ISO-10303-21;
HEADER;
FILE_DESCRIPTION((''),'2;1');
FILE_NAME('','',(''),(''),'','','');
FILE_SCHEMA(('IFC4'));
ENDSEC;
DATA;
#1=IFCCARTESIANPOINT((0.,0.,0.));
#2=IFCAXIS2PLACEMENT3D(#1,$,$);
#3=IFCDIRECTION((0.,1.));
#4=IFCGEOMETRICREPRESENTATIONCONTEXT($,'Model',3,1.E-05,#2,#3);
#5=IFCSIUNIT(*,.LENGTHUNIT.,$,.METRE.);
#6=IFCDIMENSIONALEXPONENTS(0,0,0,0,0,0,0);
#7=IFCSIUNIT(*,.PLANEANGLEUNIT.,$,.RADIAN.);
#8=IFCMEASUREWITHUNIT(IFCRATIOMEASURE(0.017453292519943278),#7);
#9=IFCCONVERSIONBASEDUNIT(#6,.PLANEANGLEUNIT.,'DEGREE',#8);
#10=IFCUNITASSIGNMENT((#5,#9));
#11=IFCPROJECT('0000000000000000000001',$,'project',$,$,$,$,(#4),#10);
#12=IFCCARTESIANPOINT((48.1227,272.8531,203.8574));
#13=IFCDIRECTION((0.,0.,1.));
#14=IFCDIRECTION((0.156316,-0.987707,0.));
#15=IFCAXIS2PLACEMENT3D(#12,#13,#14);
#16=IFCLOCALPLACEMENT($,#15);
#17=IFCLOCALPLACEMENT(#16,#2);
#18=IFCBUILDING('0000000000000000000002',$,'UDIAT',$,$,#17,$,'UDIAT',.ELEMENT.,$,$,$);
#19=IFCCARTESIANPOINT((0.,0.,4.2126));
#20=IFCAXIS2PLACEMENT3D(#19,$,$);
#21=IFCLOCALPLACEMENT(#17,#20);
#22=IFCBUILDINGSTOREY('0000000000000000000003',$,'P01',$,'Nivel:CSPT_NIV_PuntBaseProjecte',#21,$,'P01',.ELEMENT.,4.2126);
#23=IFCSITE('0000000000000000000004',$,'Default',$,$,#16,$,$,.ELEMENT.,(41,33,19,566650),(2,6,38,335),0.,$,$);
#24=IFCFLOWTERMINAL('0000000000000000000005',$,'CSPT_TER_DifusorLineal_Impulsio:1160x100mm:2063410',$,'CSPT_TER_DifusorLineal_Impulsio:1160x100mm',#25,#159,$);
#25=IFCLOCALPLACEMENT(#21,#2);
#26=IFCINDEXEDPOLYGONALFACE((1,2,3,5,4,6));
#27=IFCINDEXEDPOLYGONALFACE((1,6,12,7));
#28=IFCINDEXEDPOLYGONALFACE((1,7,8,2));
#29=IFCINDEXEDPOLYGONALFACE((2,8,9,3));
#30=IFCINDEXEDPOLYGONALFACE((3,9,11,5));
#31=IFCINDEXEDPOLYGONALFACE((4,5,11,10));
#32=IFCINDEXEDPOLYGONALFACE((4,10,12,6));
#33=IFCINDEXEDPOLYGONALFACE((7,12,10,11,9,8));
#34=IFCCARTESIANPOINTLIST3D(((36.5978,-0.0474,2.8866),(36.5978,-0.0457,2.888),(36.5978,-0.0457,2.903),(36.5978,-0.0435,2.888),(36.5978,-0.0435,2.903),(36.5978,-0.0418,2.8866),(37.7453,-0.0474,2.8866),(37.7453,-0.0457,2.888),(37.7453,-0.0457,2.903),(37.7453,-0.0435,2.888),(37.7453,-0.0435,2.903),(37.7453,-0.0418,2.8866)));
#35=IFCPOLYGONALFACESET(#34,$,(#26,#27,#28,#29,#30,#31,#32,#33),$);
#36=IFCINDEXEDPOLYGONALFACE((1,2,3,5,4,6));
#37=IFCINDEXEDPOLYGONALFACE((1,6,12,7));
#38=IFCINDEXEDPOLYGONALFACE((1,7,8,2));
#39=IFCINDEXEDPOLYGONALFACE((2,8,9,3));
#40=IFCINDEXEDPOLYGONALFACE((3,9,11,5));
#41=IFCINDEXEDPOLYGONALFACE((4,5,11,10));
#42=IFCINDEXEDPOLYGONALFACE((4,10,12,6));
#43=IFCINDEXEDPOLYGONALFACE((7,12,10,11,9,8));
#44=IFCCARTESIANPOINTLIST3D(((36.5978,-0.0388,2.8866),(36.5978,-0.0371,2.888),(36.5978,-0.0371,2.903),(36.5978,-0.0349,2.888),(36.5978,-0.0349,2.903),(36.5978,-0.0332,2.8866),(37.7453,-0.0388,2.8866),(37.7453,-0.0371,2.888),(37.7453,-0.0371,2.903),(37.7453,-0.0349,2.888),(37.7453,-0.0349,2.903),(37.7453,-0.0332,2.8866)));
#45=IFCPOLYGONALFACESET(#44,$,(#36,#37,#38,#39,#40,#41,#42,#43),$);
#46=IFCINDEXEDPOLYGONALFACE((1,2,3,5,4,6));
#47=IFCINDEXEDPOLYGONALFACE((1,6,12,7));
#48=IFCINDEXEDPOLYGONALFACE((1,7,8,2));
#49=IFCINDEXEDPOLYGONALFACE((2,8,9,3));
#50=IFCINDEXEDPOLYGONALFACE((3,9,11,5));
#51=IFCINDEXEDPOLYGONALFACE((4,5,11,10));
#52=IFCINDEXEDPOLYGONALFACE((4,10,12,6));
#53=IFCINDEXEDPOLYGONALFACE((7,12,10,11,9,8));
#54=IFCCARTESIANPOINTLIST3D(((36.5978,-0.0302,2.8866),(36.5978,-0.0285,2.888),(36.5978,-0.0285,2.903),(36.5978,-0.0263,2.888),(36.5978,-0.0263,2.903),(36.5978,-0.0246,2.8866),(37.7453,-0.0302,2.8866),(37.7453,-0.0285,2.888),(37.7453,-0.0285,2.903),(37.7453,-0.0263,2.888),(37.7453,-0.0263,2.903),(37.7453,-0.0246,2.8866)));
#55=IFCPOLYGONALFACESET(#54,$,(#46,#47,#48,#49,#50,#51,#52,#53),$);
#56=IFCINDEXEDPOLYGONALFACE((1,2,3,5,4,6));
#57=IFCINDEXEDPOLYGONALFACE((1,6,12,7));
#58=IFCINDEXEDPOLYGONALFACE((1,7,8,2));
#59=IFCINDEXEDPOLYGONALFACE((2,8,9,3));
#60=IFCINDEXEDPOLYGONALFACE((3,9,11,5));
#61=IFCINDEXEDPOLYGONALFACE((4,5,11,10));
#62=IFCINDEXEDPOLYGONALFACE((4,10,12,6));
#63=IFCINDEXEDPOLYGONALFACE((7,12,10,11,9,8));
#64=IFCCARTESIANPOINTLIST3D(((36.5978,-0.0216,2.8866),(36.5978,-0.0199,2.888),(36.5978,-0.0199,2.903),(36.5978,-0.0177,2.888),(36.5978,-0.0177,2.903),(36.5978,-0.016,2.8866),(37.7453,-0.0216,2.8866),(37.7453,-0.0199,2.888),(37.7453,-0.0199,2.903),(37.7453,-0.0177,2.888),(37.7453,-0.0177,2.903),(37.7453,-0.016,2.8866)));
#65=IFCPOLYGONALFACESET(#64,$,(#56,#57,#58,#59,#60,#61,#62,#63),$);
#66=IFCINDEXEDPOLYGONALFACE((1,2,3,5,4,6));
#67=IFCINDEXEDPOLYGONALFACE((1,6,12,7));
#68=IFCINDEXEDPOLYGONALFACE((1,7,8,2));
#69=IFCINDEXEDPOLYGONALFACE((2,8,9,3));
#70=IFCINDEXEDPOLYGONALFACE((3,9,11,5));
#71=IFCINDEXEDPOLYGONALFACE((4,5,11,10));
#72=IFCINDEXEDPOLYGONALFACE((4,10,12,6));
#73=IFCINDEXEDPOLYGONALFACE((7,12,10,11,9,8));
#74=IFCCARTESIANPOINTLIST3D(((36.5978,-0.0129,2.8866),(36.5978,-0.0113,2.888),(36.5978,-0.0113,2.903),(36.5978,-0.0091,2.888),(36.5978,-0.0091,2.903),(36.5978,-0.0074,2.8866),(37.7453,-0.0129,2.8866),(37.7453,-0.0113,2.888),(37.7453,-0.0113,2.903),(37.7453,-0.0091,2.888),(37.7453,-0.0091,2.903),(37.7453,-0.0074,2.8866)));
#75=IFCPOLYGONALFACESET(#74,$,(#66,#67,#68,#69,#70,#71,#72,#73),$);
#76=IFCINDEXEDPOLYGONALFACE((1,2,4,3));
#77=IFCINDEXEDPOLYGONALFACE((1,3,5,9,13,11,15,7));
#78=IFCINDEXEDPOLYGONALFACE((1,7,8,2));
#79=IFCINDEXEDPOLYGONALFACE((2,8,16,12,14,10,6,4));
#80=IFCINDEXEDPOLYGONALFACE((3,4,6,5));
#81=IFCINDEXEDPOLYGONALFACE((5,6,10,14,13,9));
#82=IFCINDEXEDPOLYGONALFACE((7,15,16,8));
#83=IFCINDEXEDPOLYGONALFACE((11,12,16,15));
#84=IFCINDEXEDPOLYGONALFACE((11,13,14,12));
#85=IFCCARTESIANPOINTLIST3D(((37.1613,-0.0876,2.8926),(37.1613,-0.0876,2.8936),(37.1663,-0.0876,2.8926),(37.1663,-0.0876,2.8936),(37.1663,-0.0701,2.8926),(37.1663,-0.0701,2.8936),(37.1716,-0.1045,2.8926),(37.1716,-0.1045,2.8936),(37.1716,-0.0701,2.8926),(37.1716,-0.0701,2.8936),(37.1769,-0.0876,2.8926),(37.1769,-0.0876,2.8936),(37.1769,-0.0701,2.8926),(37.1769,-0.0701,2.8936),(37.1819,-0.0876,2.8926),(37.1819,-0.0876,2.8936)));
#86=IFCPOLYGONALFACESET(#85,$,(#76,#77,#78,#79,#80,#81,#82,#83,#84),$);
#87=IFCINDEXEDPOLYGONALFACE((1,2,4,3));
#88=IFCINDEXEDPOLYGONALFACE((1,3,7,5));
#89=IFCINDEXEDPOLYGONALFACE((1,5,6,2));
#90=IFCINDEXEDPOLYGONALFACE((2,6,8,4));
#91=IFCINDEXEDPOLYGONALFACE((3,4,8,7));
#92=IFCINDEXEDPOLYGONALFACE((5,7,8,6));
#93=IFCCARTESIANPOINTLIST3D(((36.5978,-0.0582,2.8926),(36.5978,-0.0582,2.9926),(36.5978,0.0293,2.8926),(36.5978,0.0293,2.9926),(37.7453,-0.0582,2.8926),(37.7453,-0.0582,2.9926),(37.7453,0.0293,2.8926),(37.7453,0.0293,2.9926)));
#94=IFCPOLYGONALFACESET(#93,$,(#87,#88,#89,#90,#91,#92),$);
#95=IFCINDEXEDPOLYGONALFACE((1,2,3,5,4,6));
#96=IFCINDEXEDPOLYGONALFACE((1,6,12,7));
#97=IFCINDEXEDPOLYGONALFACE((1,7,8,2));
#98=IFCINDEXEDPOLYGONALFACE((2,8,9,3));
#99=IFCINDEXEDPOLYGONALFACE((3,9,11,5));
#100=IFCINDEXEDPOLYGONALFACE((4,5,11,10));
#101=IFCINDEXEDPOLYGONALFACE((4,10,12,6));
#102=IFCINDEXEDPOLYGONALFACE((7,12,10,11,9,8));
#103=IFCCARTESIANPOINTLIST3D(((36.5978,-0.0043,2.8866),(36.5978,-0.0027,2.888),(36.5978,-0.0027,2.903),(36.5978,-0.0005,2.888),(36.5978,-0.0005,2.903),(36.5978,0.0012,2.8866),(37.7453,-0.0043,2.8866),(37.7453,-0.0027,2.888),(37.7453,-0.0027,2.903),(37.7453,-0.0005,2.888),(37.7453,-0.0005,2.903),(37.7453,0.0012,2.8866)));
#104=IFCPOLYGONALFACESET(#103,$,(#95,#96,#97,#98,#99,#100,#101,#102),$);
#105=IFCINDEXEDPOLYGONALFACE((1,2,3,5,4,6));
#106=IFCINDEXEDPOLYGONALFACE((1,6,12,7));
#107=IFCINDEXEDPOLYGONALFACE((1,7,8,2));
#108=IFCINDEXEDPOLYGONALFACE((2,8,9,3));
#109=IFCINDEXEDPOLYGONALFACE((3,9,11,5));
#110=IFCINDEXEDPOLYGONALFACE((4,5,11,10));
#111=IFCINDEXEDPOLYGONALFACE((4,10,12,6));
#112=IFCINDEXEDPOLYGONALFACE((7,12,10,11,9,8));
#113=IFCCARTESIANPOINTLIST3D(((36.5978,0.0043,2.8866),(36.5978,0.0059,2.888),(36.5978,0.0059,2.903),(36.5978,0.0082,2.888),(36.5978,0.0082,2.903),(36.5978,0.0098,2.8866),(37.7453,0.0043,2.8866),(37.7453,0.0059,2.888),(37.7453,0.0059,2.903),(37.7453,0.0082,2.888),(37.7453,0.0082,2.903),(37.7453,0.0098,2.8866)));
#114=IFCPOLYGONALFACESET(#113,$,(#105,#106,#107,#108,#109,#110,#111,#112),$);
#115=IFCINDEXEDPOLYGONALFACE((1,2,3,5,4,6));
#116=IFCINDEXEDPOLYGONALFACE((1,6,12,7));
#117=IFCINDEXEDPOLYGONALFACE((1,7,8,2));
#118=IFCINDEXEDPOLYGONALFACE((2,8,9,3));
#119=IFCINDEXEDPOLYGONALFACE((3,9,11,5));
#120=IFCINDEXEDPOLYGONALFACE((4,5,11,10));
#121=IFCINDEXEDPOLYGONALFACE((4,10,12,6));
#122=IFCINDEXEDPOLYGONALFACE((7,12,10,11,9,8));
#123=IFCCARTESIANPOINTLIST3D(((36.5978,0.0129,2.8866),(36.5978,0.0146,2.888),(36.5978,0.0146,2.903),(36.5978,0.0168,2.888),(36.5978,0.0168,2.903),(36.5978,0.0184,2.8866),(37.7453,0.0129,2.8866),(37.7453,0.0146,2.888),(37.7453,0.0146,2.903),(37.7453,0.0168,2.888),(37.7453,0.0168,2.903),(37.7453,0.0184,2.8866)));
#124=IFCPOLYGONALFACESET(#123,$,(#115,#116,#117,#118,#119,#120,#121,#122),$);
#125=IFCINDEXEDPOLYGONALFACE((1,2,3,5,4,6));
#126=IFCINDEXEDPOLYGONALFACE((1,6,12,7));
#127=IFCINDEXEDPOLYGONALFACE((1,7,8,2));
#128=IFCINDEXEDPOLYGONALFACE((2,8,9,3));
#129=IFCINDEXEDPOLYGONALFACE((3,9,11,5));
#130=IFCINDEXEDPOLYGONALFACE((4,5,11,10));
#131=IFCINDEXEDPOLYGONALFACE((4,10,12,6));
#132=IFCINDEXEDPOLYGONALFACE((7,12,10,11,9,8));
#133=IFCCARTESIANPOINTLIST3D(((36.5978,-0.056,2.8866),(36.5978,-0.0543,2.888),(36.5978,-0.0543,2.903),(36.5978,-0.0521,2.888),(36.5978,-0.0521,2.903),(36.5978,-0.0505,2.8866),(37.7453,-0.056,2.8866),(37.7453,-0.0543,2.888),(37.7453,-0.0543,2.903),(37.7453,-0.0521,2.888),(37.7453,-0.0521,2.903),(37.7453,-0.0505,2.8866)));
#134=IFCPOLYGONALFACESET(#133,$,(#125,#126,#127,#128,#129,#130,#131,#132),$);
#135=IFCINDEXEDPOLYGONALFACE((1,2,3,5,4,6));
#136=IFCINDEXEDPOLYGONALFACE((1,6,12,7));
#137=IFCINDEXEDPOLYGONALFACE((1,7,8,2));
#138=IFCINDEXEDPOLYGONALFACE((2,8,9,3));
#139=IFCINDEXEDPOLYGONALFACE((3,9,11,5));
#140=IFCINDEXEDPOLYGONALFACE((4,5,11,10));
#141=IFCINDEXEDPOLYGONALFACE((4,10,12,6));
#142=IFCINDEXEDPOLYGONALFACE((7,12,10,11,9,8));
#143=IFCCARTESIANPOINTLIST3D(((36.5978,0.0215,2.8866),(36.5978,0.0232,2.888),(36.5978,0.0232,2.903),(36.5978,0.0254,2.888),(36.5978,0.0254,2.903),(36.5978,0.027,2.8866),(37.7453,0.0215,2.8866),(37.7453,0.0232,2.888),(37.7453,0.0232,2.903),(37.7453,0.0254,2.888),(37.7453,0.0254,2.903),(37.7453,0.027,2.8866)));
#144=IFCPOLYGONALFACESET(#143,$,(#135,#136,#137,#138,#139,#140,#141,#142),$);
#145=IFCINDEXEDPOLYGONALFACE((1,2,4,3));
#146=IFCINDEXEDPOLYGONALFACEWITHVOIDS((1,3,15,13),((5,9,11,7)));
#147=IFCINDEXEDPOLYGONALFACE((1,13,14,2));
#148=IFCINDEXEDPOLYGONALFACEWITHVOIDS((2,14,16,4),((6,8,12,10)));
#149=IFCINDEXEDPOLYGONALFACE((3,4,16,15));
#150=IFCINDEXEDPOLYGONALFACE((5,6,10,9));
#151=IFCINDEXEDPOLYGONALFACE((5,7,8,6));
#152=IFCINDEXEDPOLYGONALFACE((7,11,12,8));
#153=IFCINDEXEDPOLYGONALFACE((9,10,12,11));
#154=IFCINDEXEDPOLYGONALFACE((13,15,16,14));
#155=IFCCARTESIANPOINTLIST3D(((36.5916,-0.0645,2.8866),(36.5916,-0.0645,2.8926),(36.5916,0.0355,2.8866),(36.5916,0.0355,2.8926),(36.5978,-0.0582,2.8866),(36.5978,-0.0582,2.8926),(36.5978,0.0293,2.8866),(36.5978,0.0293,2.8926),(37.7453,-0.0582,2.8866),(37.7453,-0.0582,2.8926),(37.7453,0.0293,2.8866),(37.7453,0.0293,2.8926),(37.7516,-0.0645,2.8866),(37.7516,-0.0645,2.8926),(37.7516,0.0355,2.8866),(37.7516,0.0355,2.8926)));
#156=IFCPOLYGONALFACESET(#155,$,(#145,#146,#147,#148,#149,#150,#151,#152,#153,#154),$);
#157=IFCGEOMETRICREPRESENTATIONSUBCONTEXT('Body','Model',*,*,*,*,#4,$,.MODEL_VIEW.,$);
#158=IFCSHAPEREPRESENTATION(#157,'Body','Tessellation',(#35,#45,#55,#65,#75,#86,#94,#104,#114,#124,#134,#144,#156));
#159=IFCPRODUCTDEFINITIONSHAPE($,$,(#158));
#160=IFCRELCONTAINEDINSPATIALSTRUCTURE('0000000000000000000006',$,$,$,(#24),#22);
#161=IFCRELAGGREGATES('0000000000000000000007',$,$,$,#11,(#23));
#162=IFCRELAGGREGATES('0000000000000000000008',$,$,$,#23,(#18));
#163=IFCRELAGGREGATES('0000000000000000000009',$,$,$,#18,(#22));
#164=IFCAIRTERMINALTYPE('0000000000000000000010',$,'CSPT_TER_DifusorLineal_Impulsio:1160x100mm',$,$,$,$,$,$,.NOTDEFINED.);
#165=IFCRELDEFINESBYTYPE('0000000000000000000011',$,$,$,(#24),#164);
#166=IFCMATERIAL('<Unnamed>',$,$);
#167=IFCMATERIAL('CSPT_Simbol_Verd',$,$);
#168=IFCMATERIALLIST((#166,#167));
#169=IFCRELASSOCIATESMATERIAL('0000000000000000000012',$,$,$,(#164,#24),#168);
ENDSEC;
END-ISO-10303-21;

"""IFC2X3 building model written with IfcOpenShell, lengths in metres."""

from ifc_helpers import new_model, entity, si_unit, converted_unit, direction, frame, origin, origin_2d_with_axis, place, context, subcontext, project, spatial, polyline, rectangle, outline, extrude, source, transform, mapped, material, material_list, type_object, type_shapes, element, save


model = new_model("IFC2X3")

# Units and contexts
model_context = context("Model", 3, precision=1e-05, world=origin(), true_north=direction((0.0, 1.0)))
body_context = subcontext(model_context, "Body", "Model", "MODEL_VIEW")
ifc_project = project(units=[si_unit("LENGTHUNIT", "METRE"), converted_unit("PLANEANGLEUNIT", "DEGREE", entity("IfcRatioMeasure", 0.017453292519943278), si_unit("PLANEANGLEUNIT", "RADIAN"), dimensions=[0, 0, 0, 0, 0, 0, 0])], contexts=[model_context])

# Site, building, storey
site_placement = place(None, frame((48.1227, 272.8531, 203.8574), z_axis=(0.0, 0.0, 1.0), x_axis=(0.156316, -0.987707, 0.0)))
site = spatial("IfcSite", under=ifc_project, at=site_placement, Name="Default", CompositionType="ELEMENT", RefLatitude=(41, 33, 19, 566650), RefLongitude=(2, 6, 38, 335), RefElevation=0.0)
building_placement = place(site_placement, origin())
building = spatial("IfcBuilding", under=site, at=building_placement, Name="UDIAT", LongName="UDIAT", CompositionType="ELEMENT")
storey_placement = place(building_placement, frame((0.0, 0.0, 4.2126)))
storey = spatial("IfcBuildingStorey", under=building, at=storey_placement, Name="P01", ObjectType="Nivel:CSPT_NIV_PuntBaseProjecte", LongName="P01", CompositionType="ELEMENT", Elevation=4.2126)

# Shared definitions
ifc_material_1 = material(Name="<Unnamed>")

# Flow terminal
ifc_material_2 = material(Name="CSPT_Simbol_Verd")
ifc_material_list = material_list([ifc_material_1, ifc_material_2])
air_terminal_type = type_object("IfcAirTerminalType", Name="CSPT_TER_DifusorLineal_Impulsio:1160x100mm", PredefinedType="NOTDEFINED", material=ifc_material_list)
shared_shape_1 = source(origin(), body_context, "Body", "SweptSolid", [
    extrude(outline(polyline([(0.0037, 0.0028), (0.0059, 0.0028), (0.0016, 0.0063), (0.002, 0.0042), (-0.0074, -0.0074), (-0.0057, -0.0088), (0.0037, 0.0028)])), frame((-0.5737, 0.0301, -0.0001), z_axis=(1.0, 0.0, 0.0), x_axis=(0.0, -0.776119, -0.630587)), (0.0, 0.0, 1.0), 1.1475),
    extrude(outline(polyline([(0.0037, 0.0028), (0.0059, 0.0028), (0.0016, 0.0063), (0.002, 0.0042), (-0.0074, -0.0074), (-0.0057, -0.0088), (0.0037, 0.0028)])), frame((-0.5737, 0.0215, -0.0001), z_axis=(1.0, 0.0, 0.0), x_axis=(0.0, -0.776119, -0.630587)), (0.0, 0.0, 1.0), 1.1475),
    extrude(outline(polyline([(0.0037, 0.0028), (0.0059, 0.0028), (0.0016, 0.0063), (0.002, 0.0042), (-0.0074, -0.0074), (-0.0057, -0.0088), (0.0037, 0.0028)])), frame((-0.5737, 0.0129, -0.0001), z_axis=(1.0, 0.0, 0.0), x_axis=(0.0, -0.776119, -0.630587)), (0.0, 0.0, 1.0), 1.1475),
    extrude(outline(polyline([(0.0037, 0.0028), (0.0059, 0.0028), (0.0016, 0.0063), (0.002, 0.0042), (-0.0074, -0.0074), (-0.0057, -0.0088), (0.0037, 0.0028)])), frame((-0.5737, 0.0043, -0.0001), z_axis=(1.0, 0.0, 0.0), x_axis=(0.0, -0.776119, -0.630587)), (0.0, 0.0, 1.0), 1.1475),
    extrude(outline(polyline([(0.0037, 0.0028), (0.0059, 0.0028), (0.0016, 0.0063), (0.002, 0.0042), (-0.0074, -0.0074), (-0.0057, -0.0088), (0.0037, 0.0028)])), frame((-0.5737, -0.0043, -0.0001), z_axis=(1.0, 0.0, 0.0), x_axis=(0.0, -0.776119, -0.630587)), (0.0, 0.0, 1.0), 1.1475),
    extrude(outline(polyline([(0.0, -0.013), (0.0053, -0.013), (0.0053, 0.0045), (0.0103, 0.0045), (0.0, 0.0213), (-0.0103, 0.0045), (-0.0053, 0.0045), (-0.0053, -0.013), (0.0, -0.013)])), frame((0.0, 0.0687, 0.0)), (0.0, 0.0, 1.0), 0.001),
    extrude(rectangle(XDim=1.1475, YDim=0.0875, at=origin_2d_with_axis()), frame((0.0, 0.0, 0.0), z_axis=(0.0, 0.0, 1.0), x_axis=(-1.0, 0.0, 0.0)), (0.0, 0.0, 1.0), 0.1),
    extrude(outline(polyline([(0.0037, 0.0028), (0.0059, 0.0028), (0.0016, 0.0063), (0.002, 0.0042), (-0.0074, -0.0074), (-0.0057, -0.0088), (0.0037, 0.0028)])), frame((-0.5737, -0.0129, -0.0001), z_axis=(1.0, 0.0, 0.0), x_axis=(0.0, -0.776119, -0.630587)), (0.0, 0.0, 1.0), 1.1475),
    extrude(outline(polyline([(0.0037, 0.0028), (0.0059, 0.0028), (0.0016, 0.0063), (0.002, 0.0042), (-0.0074, -0.0074), (-0.0057, -0.0088), (0.0037, 0.0028)])), frame((-0.5737, -0.0215, -0.0001), z_axis=(1.0, 0.0, 0.0), x_axis=(0.0, -0.776119, -0.630587)), (0.0, 0.0, 1.0), 1.1475),
    extrude(outline(polyline([(0.0037, 0.0028), (0.0059, 0.0028), (0.0016, 0.0063), (0.002, 0.0042), (-0.0074, -0.0074), (-0.0057, -0.0088), (0.0037, 0.0028)])), frame((-0.5737, -0.0301, -0.0001), z_axis=(1.0, 0.0, 0.0), x_axis=(0.0, -0.776119, -0.630587)), (0.0, 0.0, 1.0), 1.1475),
    extrude(outline(polyline([(0.0037, 0.0028), (0.0059, 0.0028), (0.0016, 0.0063), (0.002, 0.0042), (-0.0074, -0.0074), (-0.0057, -0.0088), (0.0037, 0.0028)])), frame((-0.5737, 0.0388, -0.0001), z_axis=(1.0, 0.0, 0.0), x_axis=(0.0, -0.776119, -0.630587)), (0.0, 0.0, 1.0), 1.1475),
    extrude(outline(polyline([(0.0037, 0.0028), (0.0059, 0.0028), (0.0016, 0.0063), (0.002, 0.0042), (-0.0074, -0.0074), (-0.0057, -0.0088), (0.0037, 0.0028)])), frame((-0.5737, -0.0387, -0.0001), z_axis=(1.0, 0.0, 0.0), x_axis=(0.0, -0.776119, -0.630587)), (0.0, 0.0, 1.0), 1.1475),
    extrude(outline(polyline([(-0.58, -0.05), (0.58, -0.05), (0.58, 0.05), (-0.58, 0.05), (-0.58, -0.05)]), holes=[polyline([(-0.5738, -0.0438), (-0.5738, 0.0437), (0.5737, 0.0437), (0.5737, -0.0438), (-0.5738, -0.0438)])]), frame((0.0, 0.0, -0.006), z_axis=(0.0, 0.0, 1.0), x_axis=(-1.0, 0.0, 0.0)), (0.0, 0.0, 1.0), 0.006),
])
type_shapes(air_terminal_type, [shared_shape_1])
for number, where, z_axis, x_axis, name in (
    (1, (37.1716, -0.0145, 2.8926), (0.0, 0.0, 1.0), (-1.0, 0.0, 0.0), "CSPT_TER_DifusorLineal_Impulsio:1160x100mm:2063410"),
):
    element("IfcFlowTerminal", number, at=place(storey_placement, frame(where, z_axis=z_axis, x_axis=x_axis)), inside=storey, type_object=air_terminal_type, material=ifc_material_list, Name=name, ObjectType="CSPT_TER_DifusorLineal_Impulsio:1160x100mm", context=body_context, shape_type="MappedRepresentation", body=[
        mapped(shared_shape_1, transform((0.0, 0.0, 0.0), scale=1.0)),
    ])

save(model, "model.ifc")
